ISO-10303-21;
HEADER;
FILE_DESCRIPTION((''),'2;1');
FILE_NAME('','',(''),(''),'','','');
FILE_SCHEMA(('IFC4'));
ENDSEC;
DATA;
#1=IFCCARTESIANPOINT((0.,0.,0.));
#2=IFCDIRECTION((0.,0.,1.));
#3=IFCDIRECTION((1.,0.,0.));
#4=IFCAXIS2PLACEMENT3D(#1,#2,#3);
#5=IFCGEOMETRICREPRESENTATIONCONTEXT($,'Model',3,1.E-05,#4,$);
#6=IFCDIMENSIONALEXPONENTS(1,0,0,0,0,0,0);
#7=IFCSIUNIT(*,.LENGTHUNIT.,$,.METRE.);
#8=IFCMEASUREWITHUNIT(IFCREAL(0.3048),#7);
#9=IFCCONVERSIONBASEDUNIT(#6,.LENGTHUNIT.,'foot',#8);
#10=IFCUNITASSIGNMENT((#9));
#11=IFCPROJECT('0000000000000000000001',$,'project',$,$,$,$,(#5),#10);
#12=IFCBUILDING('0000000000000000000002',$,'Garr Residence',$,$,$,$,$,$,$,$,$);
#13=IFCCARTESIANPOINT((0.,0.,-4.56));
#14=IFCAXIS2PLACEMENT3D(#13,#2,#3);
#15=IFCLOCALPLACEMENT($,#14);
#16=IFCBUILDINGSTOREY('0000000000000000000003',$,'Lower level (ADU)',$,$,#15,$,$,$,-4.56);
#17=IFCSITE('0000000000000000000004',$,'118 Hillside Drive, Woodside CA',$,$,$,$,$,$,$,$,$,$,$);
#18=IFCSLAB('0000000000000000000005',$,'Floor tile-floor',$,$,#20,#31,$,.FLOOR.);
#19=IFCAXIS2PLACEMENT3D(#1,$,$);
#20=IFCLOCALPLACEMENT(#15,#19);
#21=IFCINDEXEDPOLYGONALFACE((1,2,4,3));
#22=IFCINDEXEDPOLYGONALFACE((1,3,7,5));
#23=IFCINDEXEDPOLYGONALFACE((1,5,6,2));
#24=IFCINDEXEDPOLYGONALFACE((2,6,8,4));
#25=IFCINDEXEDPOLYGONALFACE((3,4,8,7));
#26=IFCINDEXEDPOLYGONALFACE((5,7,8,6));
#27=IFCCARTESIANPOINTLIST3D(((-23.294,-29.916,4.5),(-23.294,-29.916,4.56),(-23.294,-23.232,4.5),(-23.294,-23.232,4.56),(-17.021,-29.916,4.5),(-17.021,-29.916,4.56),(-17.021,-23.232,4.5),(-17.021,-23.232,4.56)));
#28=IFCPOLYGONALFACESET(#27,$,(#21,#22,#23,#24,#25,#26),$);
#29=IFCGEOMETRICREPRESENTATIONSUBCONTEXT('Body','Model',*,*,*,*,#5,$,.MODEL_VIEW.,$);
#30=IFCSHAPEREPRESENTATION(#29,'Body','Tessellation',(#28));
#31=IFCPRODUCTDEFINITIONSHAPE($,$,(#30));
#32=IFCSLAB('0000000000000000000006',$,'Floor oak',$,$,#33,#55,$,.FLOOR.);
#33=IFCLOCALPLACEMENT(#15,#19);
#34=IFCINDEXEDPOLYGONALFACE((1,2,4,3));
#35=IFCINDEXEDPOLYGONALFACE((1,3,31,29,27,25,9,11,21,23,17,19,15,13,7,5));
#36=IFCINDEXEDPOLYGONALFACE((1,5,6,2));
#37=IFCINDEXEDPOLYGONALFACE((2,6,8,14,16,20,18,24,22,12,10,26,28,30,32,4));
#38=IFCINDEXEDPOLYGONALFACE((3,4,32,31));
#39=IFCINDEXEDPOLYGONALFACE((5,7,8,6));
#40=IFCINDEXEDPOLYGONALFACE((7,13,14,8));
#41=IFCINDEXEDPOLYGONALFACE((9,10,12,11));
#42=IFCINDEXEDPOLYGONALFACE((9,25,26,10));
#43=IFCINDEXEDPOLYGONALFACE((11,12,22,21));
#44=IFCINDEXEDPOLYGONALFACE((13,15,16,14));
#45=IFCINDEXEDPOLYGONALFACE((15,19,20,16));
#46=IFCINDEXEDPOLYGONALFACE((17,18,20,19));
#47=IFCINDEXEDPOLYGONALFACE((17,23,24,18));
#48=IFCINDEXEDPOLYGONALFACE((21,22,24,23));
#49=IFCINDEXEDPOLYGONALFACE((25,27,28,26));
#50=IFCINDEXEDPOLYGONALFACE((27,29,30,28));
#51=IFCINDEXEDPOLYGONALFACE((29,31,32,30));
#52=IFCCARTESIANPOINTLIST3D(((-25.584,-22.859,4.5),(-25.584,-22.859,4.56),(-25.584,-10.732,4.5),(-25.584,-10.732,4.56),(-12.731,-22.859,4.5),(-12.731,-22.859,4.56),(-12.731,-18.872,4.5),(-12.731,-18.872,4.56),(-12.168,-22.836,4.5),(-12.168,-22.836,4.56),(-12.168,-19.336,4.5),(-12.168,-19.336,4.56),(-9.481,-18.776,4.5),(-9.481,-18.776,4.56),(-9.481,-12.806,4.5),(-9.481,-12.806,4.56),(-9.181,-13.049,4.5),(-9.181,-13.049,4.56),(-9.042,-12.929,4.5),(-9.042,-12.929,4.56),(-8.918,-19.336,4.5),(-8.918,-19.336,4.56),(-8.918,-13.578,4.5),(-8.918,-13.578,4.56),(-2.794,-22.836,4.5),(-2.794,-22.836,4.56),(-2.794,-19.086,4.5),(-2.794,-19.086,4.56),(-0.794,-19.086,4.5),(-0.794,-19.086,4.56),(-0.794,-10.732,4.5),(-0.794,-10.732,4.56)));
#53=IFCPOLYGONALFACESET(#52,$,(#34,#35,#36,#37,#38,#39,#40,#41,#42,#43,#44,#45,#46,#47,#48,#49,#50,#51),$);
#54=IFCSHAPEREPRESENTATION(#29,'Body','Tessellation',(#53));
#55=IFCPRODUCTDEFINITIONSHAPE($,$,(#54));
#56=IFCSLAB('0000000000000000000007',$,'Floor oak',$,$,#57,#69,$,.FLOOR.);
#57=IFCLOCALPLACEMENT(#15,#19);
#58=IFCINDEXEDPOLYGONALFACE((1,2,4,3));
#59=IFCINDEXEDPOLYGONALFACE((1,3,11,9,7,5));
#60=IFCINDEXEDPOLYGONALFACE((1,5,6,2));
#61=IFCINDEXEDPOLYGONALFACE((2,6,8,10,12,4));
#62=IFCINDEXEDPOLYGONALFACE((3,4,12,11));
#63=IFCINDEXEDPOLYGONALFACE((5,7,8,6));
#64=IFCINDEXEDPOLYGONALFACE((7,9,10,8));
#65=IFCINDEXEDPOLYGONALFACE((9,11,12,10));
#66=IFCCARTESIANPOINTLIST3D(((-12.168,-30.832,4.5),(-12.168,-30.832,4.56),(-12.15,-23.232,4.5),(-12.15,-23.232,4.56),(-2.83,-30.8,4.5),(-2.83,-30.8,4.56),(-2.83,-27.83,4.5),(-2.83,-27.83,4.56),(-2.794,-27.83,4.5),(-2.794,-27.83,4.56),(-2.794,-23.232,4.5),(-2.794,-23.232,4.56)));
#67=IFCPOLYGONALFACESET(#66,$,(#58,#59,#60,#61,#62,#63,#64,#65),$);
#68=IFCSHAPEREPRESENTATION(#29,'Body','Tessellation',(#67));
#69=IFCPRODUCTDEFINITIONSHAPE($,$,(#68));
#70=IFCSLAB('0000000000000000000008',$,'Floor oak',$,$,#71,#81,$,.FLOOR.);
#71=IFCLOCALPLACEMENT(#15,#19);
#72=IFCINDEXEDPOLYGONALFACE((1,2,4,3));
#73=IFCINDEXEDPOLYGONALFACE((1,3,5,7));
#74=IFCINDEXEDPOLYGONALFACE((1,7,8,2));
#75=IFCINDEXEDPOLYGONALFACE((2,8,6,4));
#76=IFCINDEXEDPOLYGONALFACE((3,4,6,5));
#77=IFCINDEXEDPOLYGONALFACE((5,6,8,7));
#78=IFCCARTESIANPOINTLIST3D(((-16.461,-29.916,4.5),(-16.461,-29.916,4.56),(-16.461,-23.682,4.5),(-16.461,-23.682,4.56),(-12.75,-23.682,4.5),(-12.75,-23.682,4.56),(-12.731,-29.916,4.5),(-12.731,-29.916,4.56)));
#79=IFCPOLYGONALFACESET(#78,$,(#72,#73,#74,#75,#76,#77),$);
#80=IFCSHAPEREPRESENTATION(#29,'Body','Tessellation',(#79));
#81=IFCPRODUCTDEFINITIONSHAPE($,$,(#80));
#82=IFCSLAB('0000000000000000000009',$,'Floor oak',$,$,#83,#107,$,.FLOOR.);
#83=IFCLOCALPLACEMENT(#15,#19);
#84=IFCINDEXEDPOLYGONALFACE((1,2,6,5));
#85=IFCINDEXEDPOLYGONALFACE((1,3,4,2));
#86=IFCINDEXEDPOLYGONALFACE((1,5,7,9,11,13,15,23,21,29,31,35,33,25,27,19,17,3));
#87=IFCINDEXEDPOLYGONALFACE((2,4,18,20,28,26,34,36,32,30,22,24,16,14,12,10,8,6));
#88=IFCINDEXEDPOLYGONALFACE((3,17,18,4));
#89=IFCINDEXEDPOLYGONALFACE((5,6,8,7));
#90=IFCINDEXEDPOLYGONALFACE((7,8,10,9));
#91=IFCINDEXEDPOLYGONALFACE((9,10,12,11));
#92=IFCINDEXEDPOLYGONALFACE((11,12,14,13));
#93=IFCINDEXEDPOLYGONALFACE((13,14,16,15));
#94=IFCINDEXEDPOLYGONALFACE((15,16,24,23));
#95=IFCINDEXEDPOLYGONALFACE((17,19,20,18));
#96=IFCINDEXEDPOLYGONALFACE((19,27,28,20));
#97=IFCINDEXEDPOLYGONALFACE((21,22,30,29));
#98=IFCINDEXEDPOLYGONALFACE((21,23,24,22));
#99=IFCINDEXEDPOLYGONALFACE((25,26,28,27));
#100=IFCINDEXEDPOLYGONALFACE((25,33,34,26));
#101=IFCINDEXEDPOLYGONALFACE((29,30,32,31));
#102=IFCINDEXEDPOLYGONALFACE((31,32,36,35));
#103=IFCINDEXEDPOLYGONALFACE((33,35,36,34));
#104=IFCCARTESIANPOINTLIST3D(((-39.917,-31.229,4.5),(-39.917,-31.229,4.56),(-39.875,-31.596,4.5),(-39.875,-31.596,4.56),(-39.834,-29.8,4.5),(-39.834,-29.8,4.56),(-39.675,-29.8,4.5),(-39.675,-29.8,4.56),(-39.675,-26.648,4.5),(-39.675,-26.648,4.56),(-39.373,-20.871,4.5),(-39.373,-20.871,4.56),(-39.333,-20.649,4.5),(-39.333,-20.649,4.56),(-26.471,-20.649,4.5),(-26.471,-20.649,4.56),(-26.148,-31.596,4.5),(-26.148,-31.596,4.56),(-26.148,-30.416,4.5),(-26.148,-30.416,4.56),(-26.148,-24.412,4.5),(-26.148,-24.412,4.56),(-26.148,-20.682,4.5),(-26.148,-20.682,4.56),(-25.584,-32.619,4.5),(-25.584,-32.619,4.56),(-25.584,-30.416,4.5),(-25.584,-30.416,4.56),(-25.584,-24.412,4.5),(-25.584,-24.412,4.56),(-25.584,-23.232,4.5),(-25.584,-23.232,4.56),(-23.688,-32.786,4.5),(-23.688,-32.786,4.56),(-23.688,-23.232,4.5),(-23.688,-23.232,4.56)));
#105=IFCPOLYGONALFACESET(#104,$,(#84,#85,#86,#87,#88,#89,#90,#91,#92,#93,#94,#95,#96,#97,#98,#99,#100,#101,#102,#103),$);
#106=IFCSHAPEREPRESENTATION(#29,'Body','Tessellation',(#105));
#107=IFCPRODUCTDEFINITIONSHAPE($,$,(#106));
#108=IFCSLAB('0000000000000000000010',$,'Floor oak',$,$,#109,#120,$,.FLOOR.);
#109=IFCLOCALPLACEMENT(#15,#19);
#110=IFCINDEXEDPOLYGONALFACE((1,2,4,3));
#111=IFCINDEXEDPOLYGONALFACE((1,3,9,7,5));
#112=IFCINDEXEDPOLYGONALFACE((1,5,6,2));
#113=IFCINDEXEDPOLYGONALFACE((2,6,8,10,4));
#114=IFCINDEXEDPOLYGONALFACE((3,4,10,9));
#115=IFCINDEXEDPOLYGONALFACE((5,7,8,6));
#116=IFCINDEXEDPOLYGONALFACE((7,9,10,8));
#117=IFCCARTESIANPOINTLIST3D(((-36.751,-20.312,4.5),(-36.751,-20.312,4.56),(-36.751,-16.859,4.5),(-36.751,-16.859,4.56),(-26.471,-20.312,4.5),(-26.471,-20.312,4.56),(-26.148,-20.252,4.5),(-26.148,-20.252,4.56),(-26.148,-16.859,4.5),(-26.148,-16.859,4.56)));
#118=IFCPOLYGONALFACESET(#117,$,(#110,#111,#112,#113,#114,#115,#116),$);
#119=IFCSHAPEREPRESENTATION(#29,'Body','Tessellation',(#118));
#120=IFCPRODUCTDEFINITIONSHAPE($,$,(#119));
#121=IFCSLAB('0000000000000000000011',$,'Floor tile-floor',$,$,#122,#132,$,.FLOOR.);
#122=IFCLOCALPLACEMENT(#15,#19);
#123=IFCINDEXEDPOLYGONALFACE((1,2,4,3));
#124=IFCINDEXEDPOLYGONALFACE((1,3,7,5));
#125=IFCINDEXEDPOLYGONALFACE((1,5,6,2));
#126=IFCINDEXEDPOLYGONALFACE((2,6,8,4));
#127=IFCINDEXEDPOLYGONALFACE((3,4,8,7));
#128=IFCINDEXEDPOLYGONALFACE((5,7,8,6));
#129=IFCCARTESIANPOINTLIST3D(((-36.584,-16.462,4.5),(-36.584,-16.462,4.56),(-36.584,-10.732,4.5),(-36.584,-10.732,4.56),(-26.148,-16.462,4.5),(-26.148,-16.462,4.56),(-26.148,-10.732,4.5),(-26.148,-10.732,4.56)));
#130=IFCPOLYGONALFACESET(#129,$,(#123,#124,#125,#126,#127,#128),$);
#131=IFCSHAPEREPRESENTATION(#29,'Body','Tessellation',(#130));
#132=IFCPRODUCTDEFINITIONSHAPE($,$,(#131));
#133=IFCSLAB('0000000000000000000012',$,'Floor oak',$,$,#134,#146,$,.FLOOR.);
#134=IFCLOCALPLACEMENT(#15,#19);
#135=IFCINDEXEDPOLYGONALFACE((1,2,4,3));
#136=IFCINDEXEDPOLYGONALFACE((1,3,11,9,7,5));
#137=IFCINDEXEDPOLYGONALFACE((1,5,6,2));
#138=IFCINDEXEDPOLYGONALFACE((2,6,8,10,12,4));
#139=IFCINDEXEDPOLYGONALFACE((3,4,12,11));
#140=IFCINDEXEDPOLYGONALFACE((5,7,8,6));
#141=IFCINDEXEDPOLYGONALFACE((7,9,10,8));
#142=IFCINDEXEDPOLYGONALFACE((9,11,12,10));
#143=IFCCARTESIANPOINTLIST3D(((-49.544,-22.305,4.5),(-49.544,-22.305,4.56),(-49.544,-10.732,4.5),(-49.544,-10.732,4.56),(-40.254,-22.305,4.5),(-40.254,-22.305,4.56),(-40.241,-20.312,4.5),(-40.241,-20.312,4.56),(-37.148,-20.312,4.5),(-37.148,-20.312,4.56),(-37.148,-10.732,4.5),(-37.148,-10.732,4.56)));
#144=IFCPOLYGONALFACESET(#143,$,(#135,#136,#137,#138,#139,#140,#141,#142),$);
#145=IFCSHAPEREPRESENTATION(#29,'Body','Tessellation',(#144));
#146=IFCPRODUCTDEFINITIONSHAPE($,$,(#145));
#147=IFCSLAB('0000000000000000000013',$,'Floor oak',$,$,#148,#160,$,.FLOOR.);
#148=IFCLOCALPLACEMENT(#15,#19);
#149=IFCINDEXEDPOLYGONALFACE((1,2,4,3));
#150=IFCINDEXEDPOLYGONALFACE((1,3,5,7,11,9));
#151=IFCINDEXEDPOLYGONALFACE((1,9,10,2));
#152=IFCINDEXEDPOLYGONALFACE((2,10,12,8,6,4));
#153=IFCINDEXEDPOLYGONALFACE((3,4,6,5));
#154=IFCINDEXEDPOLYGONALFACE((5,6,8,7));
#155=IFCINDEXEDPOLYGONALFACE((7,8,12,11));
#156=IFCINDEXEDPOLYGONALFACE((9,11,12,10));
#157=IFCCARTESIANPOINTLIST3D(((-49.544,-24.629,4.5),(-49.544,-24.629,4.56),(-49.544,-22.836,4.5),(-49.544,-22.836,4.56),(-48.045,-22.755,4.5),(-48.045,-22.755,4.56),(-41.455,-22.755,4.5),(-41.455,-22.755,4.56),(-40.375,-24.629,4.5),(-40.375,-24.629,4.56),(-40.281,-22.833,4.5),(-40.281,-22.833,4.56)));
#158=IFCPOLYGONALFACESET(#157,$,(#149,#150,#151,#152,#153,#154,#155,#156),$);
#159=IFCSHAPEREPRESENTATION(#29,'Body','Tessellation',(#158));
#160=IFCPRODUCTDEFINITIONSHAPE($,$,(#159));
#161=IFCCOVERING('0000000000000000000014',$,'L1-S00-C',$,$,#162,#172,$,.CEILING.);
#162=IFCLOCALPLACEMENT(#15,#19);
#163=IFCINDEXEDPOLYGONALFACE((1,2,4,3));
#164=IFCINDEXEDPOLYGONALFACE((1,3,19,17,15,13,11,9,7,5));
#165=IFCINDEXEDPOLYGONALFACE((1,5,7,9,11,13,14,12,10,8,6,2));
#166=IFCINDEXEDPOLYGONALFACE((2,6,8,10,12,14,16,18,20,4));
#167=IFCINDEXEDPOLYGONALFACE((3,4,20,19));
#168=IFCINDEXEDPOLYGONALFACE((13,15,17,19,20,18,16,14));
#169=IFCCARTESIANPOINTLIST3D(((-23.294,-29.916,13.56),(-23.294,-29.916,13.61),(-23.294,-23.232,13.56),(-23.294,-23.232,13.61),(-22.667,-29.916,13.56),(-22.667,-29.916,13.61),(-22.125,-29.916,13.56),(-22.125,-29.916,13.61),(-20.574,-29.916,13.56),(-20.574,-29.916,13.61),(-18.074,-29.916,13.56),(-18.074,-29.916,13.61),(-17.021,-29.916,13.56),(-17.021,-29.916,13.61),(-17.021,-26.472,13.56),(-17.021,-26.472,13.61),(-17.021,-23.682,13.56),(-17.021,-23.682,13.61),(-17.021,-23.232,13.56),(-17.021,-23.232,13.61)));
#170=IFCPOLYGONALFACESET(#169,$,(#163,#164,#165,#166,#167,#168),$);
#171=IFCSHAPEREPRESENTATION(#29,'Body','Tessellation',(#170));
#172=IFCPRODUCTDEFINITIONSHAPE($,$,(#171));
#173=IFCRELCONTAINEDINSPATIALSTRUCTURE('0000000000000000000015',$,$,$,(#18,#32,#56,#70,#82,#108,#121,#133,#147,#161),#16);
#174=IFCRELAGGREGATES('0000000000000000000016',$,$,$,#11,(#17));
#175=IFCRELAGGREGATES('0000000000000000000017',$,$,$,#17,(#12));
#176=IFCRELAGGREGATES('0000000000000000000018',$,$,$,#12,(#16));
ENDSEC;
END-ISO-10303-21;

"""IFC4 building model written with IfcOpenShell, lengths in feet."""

from ifc_helpers import new_model, entity, si_unit, converted_unit, frame, origin, origin_with_axes, place, context, subcontext, project, spatial, polyline, outline, extrude, element, save


model = new_model("IFC4")

# Units and contexts
model_context = context("Model", 3, precision=1e-05, world=origin_with_axes())
body_context = subcontext(model_context, "Body", "Model", "MODEL_VIEW")
ifc_project = project(units=[converted_unit("LENGTHUNIT", "foot", entity("IfcReal", 0.3048), si_unit("LENGTHUNIT", "METRE"), dimensions=[1, 0, 0, 0, 0, 0, 0])], contexts=[model_context])

# Site, building, storey
site = spatial("IfcSite", under=ifc_project, Name="118 Hillside Drive, Woodside CA")
building = spatial("IfcBuilding", under=site, Name="Garr Residence")
storey_placement = place(None, frame((0.0, 0.0, -4.56), z_axis=(0.0, 0.0, 1.0), x_axis=(1.0, 0.0, 0.0)))
storey = spatial("IfcBuildingStorey", under=building, at=storey_placement, Name="Lower level (ADU)", Elevation=-4.56)

# Slabs
slab_1_placement = place(storey_placement, frame((0.0, 0.0, 4.5), z_axis=(0.0, 0.0, 1.0), x_axis=(1.0, 0.0, 0.0)))
element("IfcSlab", 1, at=slab_1_placement, inside=storey, Name="Floor tile-floor", PredefinedType="FLOOR", context=body_context, shape_type="SweptSolid", body=[
    extrude(outline(polyline([(-23.294, -23.232), (-17.021, -23.232), (-17.021, -29.916), (-23.294, -29.916), (-23.294, -23.232)])), origin(), (0.0, 0.0, 1.0), 0.06),
])
slab_2_placement = place(storey_placement, frame((0.0, 0.0, 4.5), z_axis=(0.0, 0.0, 1.0), x_axis=(1.0, 0.0, 0.0)))
element("IfcSlab", 2, at=slab_2_placement, inside=storey, Name="Floor oak", PredefinedType="FLOOR", context=body_context, shape_type="SweptSolid", body=[
    extrude(outline(polyline([(-25.584, -10.732), (-0.794, -10.732), (-0.794, -19.086), (-2.794, -19.086), (-2.794, -22.836), (-12.168, -22.836), (-12.168, -19.336), (-8.918, -19.336), (-8.918, -13.578), (-9.181, -13.049), (-9.042, -12.929), (-9.481, -12.806), (-9.481, -18.776), (-12.731, -18.872), (-12.731, -22.859), (-25.584, -22.859), (-25.584, -10.732)])), origin(), (0.0, 0.0, 1.0), 0.06),
])
slab_3_placement = place(storey_placement, frame((0.0, 0.0, 4.5), z_axis=(0.0, 0.0, 1.0), x_axis=(1.0, 0.0, 0.0)))
element("IfcSlab", 3, at=slab_3_placement, inside=storey, Name="Floor oak", PredefinedType="FLOOR", context=body_context, shape_type="SweptSolid", body=[
    extrude(outline(polyline([(-12.168, -30.832), (-12.15, -23.232), (-2.794, -23.232), (-2.794, -27.83), (-2.83, -27.83), (-2.83, -30.8), (-12.168, -30.832)])), origin(), (0.0, 0.0, 1.0), 0.06),
])
slab_4_placement = place(storey_placement, frame((0.0, 0.0, 4.5), z_axis=(0.0, 0.0, 1.0), x_axis=(1.0, 0.0, 0.0)))
element("IfcSlab", 4, at=slab_4_placement, inside=storey, Name="Floor oak", PredefinedType="FLOOR", context=body_context, shape_type="SweptSolid", body=[
    extrude(outline(polyline([(-12.75, -23.682), (-12.731, -29.916), (-16.461, -29.916), (-16.461, -23.682), (-12.75, -23.682)])), origin(), (0.0, 0.0, 1.0), 0.06),
])
slab_5_placement = place(storey_placement, frame((0.0, 0.0, 4.5), z_axis=(0.0, 0.0, 1.0), x_axis=(1.0, 0.0, 0.0)))
element("IfcSlab", 5, at=slab_5_placement, inside=storey, Name="Floor oak", PredefinedType="FLOOR", context=body_context, shape_type="SweptSolid", body=[
    extrude(outline(polyline([(-39.917, -31.229), (-39.834, -29.8), (-39.675, -29.8), (-39.675, -26.648), (-39.373, -20.871), (-39.333, -20.649), (-26.471, -20.649), (-26.148, -20.682), (-26.148, -24.412), (-25.584, -24.412), (-25.584, -23.232), (-23.688, -23.232), (-23.688, -32.786), (-25.584, -32.619), (-25.584, -30.416), (-26.148, -30.416), (-26.148, -31.596), (-39.875, -31.596), (-39.917, -31.229)])), origin(), (0.0, 0.0, 1.0), 0.06),
])
slab_6_placement = place(storey_placement, frame((0.0, 0.0, 4.5), z_axis=(0.0, 0.0, 1.0), x_axis=(1.0, 0.0, 0.0)))
element("IfcSlab", 6, at=slab_6_placement, inside=storey, Name="Floor oak", PredefinedType="FLOOR", context=body_context, shape_type="SweptSolid", body=[
    extrude(outline(polyline([(-36.751, -20.312), (-36.751, -16.859), (-26.148, -16.859), (-26.148, -20.252), (-26.471, -20.312), (-36.751, -20.312)])), origin(), (0.0, 0.0, 1.0), 0.06),
])
slab_7_placement = place(storey_placement, frame((0.0, 0.0, 4.5), z_axis=(0.0, 0.0, 1.0), x_axis=(1.0, 0.0, 0.0)))
element("IfcSlab", 7, at=slab_7_placement, inside=storey, Name="Floor tile-floor", PredefinedType="FLOOR", context=body_context, shape_type="SweptSolid", body=[
    extrude(outline(polyline([(-36.584, -10.732), (-26.148, -10.732), (-26.148, -16.462), (-36.584, -16.462), (-36.584, -10.732)])), origin(), (0.0, 0.0, 1.0), 0.06),
])
slab_8_placement = place(storey_placement, frame((0.0, 0.0, 4.5), z_axis=(0.0, 0.0, 1.0), x_axis=(1.0, 0.0, 0.0)))
element("IfcSlab", 8, at=slab_8_placement, inside=storey, Name="Floor oak", PredefinedType="FLOOR", context=body_context, shape_type="SweptSolid", body=[
    extrude(outline(polyline([(-49.544, -22.305), (-49.544, -10.732), (-37.148, -10.732), (-37.148, -20.312), (-40.241, -20.312), (-40.254, -22.305), (-49.544, -22.305)])), origin(), (0.0, 0.0, 1.0), 0.06),
])
slab_9_placement = place(storey_placement, frame((0.0, 0.0, 4.5), z_axis=(0.0, 0.0, 1.0), x_axis=(1.0, 0.0, 0.0)))
element("IfcSlab", 9, at=slab_9_placement, inside=storey, Name="Floor oak", PredefinedType="FLOOR", context=body_context, shape_type="SweptSolid", body=[
    extrude(outline(polyline([(-48.045, -22.755), (-41.455, -22.755), (-40.281, -22.833), (-40.375, -24.629), (-49.544, -24.629), (-49.544, -22.836), (-48.045, -22.755)])), origin(), (0.0, 0.0, 1.0), 0.06),
])

# Covering
covering_1_placement = place(storey_placement, frame((0.0, 0.0, 13.56), z_axis=(0.0, 0.0, 1.0), x_axis=(1.0, 0.0, 0.0)))
element("IfcCovering", 10, at=covering_1_placement, inside=storey, Name="L1-S00-C", PredefinedType="CEILING", context=body_context, shape_type="SweptSolid", body=[
    extrude(outline(polyline([(-23.294, -23.232), (-17.021, -23.232), (-17.021, -23.682), (-17.021, -26.472), (-17.021, -29.916), (-18.074, -29.916), (-20.574, -29.916), (-22.125, -29.916), (-22.667, -29.916), (-23.294, -29.916), (-23.294, -23.232)])), origin(), (0.0, 0.0, 1.0), 0.05),
])

save(model, "model.ifc")
